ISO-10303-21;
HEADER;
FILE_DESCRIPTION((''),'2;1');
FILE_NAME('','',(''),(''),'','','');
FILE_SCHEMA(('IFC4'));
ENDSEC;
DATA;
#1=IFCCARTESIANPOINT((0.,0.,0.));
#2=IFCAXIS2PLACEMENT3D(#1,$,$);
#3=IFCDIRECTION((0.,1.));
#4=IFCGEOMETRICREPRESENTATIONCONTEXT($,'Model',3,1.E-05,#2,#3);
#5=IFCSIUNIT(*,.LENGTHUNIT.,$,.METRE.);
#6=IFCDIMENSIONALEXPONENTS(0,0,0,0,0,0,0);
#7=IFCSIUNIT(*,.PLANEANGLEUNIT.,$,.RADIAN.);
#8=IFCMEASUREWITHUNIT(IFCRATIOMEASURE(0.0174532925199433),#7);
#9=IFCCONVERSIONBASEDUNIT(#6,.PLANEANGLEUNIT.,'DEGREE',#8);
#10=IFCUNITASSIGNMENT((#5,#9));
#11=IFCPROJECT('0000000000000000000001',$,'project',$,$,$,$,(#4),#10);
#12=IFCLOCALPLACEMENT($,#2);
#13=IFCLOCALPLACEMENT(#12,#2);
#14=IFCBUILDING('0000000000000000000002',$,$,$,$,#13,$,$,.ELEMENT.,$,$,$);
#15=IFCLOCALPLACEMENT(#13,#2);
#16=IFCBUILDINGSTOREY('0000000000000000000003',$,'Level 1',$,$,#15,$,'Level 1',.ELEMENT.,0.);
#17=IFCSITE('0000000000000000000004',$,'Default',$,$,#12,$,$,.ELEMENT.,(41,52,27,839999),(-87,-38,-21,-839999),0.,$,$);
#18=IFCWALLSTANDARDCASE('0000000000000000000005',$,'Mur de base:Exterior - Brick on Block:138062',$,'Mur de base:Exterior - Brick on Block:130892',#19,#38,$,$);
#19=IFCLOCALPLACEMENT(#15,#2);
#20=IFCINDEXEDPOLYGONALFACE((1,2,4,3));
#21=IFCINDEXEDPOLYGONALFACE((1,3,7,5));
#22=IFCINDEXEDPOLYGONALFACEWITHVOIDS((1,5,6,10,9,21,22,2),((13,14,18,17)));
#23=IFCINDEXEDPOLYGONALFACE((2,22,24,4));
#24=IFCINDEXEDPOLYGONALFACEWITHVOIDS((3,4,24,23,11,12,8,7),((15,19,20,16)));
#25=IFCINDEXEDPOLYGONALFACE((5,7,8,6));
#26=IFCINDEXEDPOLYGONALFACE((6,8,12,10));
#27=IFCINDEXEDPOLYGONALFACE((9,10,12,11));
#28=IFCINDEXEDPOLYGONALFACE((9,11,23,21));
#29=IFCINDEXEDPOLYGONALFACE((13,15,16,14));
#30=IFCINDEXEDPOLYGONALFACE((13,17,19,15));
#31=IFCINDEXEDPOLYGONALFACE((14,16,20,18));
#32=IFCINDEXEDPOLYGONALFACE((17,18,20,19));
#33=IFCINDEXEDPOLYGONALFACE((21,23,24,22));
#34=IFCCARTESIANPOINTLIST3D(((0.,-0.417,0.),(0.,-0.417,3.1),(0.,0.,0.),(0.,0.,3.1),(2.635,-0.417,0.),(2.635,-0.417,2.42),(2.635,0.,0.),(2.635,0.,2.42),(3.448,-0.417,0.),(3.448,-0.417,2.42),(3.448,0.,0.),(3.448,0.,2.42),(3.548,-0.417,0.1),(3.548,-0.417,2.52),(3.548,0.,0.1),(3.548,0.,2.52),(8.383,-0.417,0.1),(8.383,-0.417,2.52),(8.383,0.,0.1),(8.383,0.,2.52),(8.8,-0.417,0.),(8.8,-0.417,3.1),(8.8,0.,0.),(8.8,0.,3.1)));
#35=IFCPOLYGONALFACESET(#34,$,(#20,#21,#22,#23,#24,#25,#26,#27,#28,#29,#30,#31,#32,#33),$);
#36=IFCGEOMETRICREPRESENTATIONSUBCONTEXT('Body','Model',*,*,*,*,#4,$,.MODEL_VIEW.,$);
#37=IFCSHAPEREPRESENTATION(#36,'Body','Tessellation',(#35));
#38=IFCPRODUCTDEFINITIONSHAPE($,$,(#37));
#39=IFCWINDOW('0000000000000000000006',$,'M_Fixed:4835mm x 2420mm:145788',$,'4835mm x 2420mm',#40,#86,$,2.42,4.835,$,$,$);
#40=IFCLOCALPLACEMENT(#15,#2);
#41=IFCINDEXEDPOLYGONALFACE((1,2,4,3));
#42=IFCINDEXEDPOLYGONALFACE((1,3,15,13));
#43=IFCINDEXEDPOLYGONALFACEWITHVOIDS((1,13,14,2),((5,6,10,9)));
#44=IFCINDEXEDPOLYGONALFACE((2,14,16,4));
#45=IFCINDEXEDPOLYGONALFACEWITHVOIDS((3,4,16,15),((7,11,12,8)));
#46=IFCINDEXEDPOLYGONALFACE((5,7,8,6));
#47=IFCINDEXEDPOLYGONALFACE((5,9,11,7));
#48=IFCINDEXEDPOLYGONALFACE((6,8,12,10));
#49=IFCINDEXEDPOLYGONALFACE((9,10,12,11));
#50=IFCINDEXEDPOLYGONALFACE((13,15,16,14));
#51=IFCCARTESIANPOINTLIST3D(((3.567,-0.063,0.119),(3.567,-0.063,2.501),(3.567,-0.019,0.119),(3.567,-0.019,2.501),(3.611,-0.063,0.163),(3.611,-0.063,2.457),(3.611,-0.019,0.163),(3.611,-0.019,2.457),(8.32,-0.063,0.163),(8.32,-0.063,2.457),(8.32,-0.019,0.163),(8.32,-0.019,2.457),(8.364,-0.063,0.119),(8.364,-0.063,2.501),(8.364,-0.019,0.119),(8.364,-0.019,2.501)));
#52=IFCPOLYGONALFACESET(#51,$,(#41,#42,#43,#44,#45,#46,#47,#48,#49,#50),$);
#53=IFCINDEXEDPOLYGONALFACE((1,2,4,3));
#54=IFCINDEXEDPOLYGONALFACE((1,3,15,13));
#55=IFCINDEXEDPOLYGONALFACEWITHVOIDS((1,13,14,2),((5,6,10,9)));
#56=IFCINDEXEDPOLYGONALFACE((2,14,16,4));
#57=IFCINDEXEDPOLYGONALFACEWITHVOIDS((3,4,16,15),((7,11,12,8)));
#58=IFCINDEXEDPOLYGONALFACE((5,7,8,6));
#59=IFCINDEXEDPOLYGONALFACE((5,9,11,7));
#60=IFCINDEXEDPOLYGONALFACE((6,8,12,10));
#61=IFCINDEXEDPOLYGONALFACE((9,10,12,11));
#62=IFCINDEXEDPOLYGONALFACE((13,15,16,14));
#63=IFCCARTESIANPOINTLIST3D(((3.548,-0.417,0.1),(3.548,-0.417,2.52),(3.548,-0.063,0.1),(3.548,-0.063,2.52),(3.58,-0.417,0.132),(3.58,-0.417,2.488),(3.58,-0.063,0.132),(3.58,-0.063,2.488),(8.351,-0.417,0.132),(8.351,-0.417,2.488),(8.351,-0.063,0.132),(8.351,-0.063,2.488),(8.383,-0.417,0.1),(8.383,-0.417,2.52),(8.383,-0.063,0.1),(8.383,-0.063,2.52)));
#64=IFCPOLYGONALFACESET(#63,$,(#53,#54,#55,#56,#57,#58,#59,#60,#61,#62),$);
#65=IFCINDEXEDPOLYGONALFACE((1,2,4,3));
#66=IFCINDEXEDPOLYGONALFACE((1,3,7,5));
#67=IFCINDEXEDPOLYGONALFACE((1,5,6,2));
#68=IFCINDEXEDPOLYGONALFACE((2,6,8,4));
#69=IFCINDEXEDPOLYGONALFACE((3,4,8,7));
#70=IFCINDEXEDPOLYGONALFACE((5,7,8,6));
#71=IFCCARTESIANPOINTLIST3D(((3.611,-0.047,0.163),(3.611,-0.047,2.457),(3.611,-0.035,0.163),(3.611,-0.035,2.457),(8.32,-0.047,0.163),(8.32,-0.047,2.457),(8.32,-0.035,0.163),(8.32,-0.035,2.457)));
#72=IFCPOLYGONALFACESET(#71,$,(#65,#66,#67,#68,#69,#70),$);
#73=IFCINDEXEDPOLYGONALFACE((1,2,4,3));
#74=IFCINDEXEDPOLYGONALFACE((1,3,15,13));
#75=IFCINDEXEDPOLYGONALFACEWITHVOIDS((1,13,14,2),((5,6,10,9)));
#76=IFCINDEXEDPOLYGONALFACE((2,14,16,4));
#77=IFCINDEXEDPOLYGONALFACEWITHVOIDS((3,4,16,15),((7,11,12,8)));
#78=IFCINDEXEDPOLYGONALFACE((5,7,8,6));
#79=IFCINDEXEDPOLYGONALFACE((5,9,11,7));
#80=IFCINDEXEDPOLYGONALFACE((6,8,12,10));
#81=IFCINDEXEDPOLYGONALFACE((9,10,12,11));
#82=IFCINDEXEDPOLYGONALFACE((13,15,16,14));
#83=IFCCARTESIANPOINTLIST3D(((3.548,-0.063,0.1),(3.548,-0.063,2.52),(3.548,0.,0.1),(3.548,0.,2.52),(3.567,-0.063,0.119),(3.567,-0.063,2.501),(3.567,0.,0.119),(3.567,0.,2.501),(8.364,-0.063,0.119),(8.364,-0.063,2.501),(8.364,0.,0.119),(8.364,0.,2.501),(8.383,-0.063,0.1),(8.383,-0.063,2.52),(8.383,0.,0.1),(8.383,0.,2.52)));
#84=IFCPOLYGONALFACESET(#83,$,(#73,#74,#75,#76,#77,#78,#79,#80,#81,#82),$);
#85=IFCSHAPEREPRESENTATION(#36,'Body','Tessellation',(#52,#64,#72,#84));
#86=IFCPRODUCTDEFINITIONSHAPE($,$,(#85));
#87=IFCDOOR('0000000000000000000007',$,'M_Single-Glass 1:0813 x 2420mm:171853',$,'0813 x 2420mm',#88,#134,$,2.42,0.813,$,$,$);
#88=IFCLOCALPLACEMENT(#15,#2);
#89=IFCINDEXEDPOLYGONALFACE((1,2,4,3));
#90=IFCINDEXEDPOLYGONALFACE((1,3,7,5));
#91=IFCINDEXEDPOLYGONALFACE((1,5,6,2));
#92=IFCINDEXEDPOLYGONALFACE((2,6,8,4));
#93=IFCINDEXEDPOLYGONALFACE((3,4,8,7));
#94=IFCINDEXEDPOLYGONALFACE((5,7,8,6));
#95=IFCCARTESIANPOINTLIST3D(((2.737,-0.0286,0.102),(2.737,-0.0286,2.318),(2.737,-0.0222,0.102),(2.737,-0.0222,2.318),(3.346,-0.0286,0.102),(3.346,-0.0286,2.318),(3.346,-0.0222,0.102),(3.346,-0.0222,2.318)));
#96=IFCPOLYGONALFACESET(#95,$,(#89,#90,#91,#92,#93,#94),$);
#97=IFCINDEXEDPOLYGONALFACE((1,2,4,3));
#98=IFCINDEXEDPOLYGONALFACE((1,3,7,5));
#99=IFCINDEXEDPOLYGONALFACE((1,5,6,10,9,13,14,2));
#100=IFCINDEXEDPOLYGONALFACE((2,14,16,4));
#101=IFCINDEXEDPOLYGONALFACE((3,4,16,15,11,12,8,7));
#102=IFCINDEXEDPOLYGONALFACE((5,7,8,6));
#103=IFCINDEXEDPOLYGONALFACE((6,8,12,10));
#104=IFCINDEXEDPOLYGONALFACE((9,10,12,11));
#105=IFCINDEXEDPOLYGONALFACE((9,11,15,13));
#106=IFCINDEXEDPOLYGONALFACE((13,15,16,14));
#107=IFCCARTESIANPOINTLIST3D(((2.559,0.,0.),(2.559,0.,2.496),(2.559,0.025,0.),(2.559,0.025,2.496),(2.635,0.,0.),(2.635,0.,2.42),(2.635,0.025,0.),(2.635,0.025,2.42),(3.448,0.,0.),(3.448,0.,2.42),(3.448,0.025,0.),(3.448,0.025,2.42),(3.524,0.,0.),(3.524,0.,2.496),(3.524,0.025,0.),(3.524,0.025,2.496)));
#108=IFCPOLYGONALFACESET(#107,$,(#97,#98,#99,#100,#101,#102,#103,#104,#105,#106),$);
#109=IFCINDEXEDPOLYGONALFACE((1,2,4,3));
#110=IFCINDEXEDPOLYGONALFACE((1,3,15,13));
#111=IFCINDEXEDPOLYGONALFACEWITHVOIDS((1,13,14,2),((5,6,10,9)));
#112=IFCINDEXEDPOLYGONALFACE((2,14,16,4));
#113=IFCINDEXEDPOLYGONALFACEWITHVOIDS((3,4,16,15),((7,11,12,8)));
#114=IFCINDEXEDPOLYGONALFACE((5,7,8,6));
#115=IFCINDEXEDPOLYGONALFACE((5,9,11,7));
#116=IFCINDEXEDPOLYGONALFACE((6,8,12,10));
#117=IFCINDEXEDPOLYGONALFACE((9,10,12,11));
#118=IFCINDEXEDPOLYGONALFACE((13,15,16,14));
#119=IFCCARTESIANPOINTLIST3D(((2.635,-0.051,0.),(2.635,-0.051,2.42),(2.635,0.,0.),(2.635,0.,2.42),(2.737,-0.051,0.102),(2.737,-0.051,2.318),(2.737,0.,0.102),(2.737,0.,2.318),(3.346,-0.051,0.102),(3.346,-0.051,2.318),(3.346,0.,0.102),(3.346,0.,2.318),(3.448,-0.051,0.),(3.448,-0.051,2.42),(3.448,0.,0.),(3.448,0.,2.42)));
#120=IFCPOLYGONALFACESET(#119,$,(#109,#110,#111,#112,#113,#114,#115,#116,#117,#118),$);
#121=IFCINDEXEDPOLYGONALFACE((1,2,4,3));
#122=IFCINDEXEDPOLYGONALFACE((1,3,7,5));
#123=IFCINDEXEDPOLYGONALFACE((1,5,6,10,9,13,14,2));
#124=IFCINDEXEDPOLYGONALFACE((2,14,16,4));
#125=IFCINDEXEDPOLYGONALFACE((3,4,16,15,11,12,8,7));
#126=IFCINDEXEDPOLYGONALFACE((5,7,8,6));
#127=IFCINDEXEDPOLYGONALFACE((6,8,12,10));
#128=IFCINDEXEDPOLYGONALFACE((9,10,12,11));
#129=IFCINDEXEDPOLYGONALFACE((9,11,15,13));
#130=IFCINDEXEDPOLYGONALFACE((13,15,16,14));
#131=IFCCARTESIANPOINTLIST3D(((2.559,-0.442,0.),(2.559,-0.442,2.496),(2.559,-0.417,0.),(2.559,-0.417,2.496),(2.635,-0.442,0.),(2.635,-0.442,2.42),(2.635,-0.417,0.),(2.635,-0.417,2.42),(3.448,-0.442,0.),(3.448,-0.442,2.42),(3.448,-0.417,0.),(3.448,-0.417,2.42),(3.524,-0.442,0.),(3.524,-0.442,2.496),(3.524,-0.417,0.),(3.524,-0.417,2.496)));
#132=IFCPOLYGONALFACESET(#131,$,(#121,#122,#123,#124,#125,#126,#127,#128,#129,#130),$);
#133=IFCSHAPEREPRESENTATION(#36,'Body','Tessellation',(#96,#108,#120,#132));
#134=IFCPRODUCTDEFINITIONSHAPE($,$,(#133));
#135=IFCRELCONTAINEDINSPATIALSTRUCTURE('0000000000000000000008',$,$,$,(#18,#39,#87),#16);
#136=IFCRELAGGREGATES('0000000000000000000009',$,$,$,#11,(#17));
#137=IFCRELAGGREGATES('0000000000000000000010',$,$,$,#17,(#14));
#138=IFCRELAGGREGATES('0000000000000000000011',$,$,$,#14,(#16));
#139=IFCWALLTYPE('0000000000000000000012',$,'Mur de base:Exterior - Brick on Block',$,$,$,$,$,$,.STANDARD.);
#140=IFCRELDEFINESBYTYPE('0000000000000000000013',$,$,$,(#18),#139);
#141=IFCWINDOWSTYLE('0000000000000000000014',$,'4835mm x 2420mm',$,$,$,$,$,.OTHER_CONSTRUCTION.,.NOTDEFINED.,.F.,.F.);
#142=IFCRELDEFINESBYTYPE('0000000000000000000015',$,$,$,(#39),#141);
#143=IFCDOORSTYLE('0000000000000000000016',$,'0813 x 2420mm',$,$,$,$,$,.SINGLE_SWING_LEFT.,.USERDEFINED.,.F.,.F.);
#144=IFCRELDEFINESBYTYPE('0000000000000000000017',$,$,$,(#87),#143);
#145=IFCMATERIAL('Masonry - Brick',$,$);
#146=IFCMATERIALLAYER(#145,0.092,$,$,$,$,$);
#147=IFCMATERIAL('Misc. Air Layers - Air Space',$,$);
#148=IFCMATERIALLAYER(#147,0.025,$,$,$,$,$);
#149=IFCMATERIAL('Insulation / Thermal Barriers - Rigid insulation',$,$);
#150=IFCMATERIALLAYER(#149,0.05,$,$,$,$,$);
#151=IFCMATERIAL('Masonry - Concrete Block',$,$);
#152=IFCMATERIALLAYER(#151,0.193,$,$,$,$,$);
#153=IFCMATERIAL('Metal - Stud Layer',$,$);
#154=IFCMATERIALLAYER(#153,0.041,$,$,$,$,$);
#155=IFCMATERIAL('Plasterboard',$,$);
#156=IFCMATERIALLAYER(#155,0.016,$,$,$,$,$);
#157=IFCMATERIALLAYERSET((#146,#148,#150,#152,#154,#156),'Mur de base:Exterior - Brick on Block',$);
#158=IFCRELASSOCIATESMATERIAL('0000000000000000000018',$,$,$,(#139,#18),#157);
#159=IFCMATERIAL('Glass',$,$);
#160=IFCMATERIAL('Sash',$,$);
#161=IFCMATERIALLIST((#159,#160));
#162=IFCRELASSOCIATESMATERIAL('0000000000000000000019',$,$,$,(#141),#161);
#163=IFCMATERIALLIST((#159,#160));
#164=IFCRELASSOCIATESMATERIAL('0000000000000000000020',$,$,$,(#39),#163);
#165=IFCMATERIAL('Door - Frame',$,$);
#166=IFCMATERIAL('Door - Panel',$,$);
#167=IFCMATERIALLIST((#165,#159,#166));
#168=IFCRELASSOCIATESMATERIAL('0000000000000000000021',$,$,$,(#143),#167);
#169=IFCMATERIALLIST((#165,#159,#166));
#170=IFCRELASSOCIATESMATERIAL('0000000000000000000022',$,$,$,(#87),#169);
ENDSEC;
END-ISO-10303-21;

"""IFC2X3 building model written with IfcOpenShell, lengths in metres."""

from ifc_helpers import new_model, entity, si_unit, converted_unit, direction, frame, frame_2d, origin, origin_2d_with_axis, place, context, subcontext, project, spatial, polyline, rectangle, outline, extrude, source, transform, mapped, material, material_list, layer, layer_set, layer_usage, type_object, type_shapes, element, fill, save


model = new_model("IFC2X3")

# Units and contexts
model_context = context("Model", 3, precision=1e-05, world=origin(), true_north=direction((0.0, 1.0)))
body_context = subcontext(model_context, "Body", "Model", "MODEL_VIEW")
ifc_project = project(units=[si_unit("LENGTHUNIT", "METRE"), converted_unit("PLANEANGLEUNIT", "DEGREE", entity("IfcRatioMeasure", 0.0174532925199433), si_unit("PLANEANGLEUNIT", "RADIAN"), dimensions=[0, 0, 0, 0, 0, 0, 0])], contexts=[model_context])

# Site, building, storey
site_placement = place(None, origin())
site = spatial("IfcSite", under=ifc_project, at=site_placement, Name="Default", CompositionType="ELEMENT", RefLatitude=(41, 52, 27, 839999), RefLongitude=(-87, -38, -21, -839999), RefElevation=0.0)
building_placement = place(site_placement, origin())
building = spatial("IfcBuilding", under=site, at=building_placement, CompositionType="ELEMENT")
storey_placement = place(building_placement, origin())
storey = spatial("IfcBuildingStorey", under=building, at=storey_placement, Name="Level 1", LongName="Level 1", CompositionType="ELEMENT", Elevation=0.0)

# Wall, openings, window, door
ifc_material_1 = material(Name="Masonry - Brick")
ifc_layer_1 = layer(ifc_material_1, 0.092)
ifc_material_2 = material(Name="Misc. Air Layers - Air Space")
ifc_layer_2 = layer(ifc_material_2, 0.025)
ifc_material_3 = material(Name="Insulation / Thermal Barriers - Rigid insulation")
ifc_layer_3 = layer(ifc_material_3, 0.05)
ifc_material_4 = material(Name="Masonry - Concrete Block")
ifc_layer_4 = layer(ifc_material_4, 0.193)
ifc_material_5 = material(Name="Metal - Stud Layer")
ifc_layer_5 = layer(ifc_material_5, 0.041)
ifc_material_6 = material(Name="Plasterboard")
ifc_layer_6 = layer(ifc_material_6, 0.016)
ifc_layer_set_1 = layer_set([ifc_layer_1, ifc_layer_2, ifc_layer_3, ifc_layer_4, ifc_layer_5, ifc_layer_6], Name="Mur de base:Exterior - Brick on Block")
ifc_layer_usage_1 = layer_usage(ifc_layer_set_1, "AXIS2", "NEGATIVE", 0.2085)
wall_type_1 = type_object("IfcWallType", Name="Mur de base:Exterior - Brick on Block", PredefinedType="STANDARD", material=ifc_layer_set_1)
wall_1_placement = place(storey_placement, frame((0.0, -0.2085, 0.0)))
wall_1 = element("IfcWallStandardCase", 1, at=wall_1_placement, inside=storey, type_object=wall_type_1, material=ifc_layer_usage_1, Name="Mur de base:Exterior - Brick on Block:138062", ObjectType="Mur de base:Exterior - Brick on Block:130892", context=body_context, shape_type="SweptSolid", body=[
    extrude(rectangle(XDim=8.8, YDim=0.417, at=frame_2d((4.4, 0.0), x_axis=(-1.0, 0.0))), origin(), (0.0, 0.0, 1.0), 3.1),
])
opening_1_placement = place(wall_1_placement, frame((2.635, -0.2085, 0.0)))
opening_1 = element("IfcOpeningElement", 2, at=opening_1_placement, cuts=wall_1, ObjectType="Opening", context=body_context, shape_type="SweptSolid", body=[
    extrude(rectangle(XDim=0.813, YDim=2.42, at=frame_2d((1.21, 0.4065), x_axis=(0.0, -1.0))), frame((0.0, 0.0, 0.0), z_axis=(0.0, 1.0, 0.0), x_axis=(0.0, 0.0, 1.0)), (0.0, 0.0, 1.0), 0.417),
])
opening_2_placement = place(wall_1_placement, frame((3.548, -0.2085, 0.1)))
opening_2 = element("IfcOpeningElement", 3, at=opening_2_placement, cuts=wall_1, ObjectType="Opening", context=body_context, shape_type="SweptSolid", body=[
    extrude(rectangle(XDim=2.42, YDim=4.835, at=frame_2d((1.21, 2.4175), x_axis=(1.0, 0.0))), frame((0.0, 0.0, 0.0), z_axis=(0.0, 1.0, 0.0), x_axis=(0.0, 0.0, 1.0)), (0.0, 0.0, 1.0), 0.417),
])
ifc_material_7 = material(Name="Glass")
ifc_material_8 = material(Name="Sash")
ifc_material_list_1 = material_list([ifc_material_7, ifc_material_8])
ifc_material_list_2 = material_list([ifc_material_7, ifc_material_8])
window_style_1 = type_object("IfcWindowStyle", Name="4835mm x 2420mm", ConstructionType="OTHER_CONSTRUCTION", OperationType="NOTDEFINED", ParameterTakesPrecedence=False, Sizeable=False, material=ifc_material_list_2)
shared_shape_1 = source(origin(), body_context, "Body", "SweptSolid", [
    extrude(outline(polyline([(-2.3985, -1.191), (2.3985, -1.191), (2.3985, 1.191), (-2.3985, 1.191), (-2.3985, -1.191)]), holes=[polyline([(-2.3545, -1.147), (-2.3545, 1.147), (2.3545, 1.147), (2.3545, -1.147), (-2.3545, -1.147)])]), frame((2.4175, 0.354, 1.21), z_axis=(0.0, 1.0, 0.0), x_axis=(1.0, 0.0, 0.0)), (0.0, 0.0, 1.0), 0.044),
    extrude(outline(polyline([(-2.4175, -1.21), (2.4175, -1.21), (2.4175, 1.21), (-2.4175, 1.21), (-2.4175, -1.21)]), holes=[polyline([(-2.3855, -1.178), (-2.3855, 1.178), (2.3855, 1.178), (2.3855, -1.178), (-2.3855, -1.178)])]), frame((2.4175, 0.0, 1.21), z_axis=(0.0, 1.0, 0.0), x_axis=(1.0, 0.0, 0.0)), (0.0, 0.0, 1.0), 0.354),
    extrude(rectangle(XDim=0.012, YDim=4.709, at=origin_2d_with_axis()), frame((2.4175, 0.376, 0.063), z_axis=(0.0, 0.0, 1.0), x_axis=(0.0, -1.0, 0.0)), (0.0, 0.0, 1.0), 2.294),
    extrude(outline(polyline([(-2.4175, -1.21), (2.4175, -1.21), (2.4175, 1.21), (-2.4175, 1.21), (-2.4175, -1.21)]), holes=[polyline([(-2.3985, -1.191), (-2.3985, 1.191), (2.3985, 1.191), (2.3985, -1.191), (-2.3985, -1.191)])]), frame((2.4175, 0.354, 1.21), z_axis=(0.0, 1.0, 0.0), x_axis=(1.0, 0.0, 0.0)), (0.0, 0.0, 1.0), 0.063),
])
type_shapes(window_style_1, [shared_shape_1])
window_1_placement = place(opening_2_placement, origin())
window_1 = element("IfcWindow", 4, at=window_1_placement, inside=storey, type_object=window_style_1, material=ifc_material_list_1, Name="M_Fixed:4835mm x 2420mm:145788", ObjectType="4835mm x 2420mm", OverallHeight=2.42, OverallWidth=4.835, context=body_context, shape_type="MappedRepresentation", body=[
    mapped(shared_shape_1, transform((0.0, 0.0, 0.0), scale=1.0)),
])
fill(opening_2, window_1)
ifc_material_9 = material(Name="Door - Frame")
ifc_material_10 = material(Name="Door - Panel")
ifc_material_list_3 = material_list([ifc_material_9, ifc_material_7, ifc_material_10])
ifc_material_list_4 = material_list([ifc_material_9, ifc_material_7, ifc_material_10])
door_style_1 = type_object("IfcDoorStyle", Name="0813 x 2420mm", ConstructionType="USERDEFINED", OperationType="SINGLE_SWING_LEFT", ParameterTakesPrecedence=False, Sizeable=False, material=ifc_material_list_4)
shared_shape_2 = source(origin(), body_context, "Body", "SweptSolid", [
    extrude(rectangle(XDim=0.609, YDim=0.0064, at=frame_2d((0.0, 0.0), x_axis=(1.0, 0.0))), frame((0.4065, 0.3916, 0.102)), (0.0, 0.0, 1.0), 2.216),
    extrude(outline(polyline([(-0.4065, -1.191), (-0.4065, 1.229), (-0.4825, 1.229), (-0.4825, -1.267), (0.4825, -1.267), (0.4825, 1.229), (0.4065, 1.229), (0.4065, -1.191), (-0.4065, -1.191)])), frame((0.4065, 0.442, 1.229), z_axis=(0.0, 1.0, 0.0), x_axis=(1.0, 0.0, 0.0)), (0.0, 0.0, -1.0), 0.025),
    extrude(outline(polyline([(-1.21, -0.4065), (1.21, -0.4065), (1.21, 0.4065), (-1.21, 0.4065), (-1.21, -0.4065)]), holes=[polyline([(-1.108, 0.3045), (1.108, 0.3045), (1.108, -0.3045), (-1.108, -0.3045), (-1.108, 0.3045)])]), frame((0.4065, 0.417, 1.21), z_axis=(0.0, -1.0, 0.0), x_axis=(0.0, 0.0, -1.0)), (0.0, 0.0, 1.0), 0.051),
    extrude(outline(polyline([(-0.4065, -1.191), (-0.4065, 1.229), (-0.4825, 1.229), (-0.4825, -1.267), (0.4825, -1.267), (0.4825, 1.229), (0.4065, 1.229), (0.4065, -1.191), (-0.4065, -1.191)])), frame((0.4065, 0.0, 1.229), z_axis=(0.0, 1.0, 0.0), x_axis=(1.0, 0.0, 0.0)), (0.0, 0.0, -1.0), 0.025),
])
type_shapes(door_style_1, [shared_shape_2])
door_1_placement = place(opening_1_placement, origin())
door_1 = element("IfcDoor", 5, at=door_1_placement, inside=storey, type_object=door_style_1, material=ifc_material_list_3, Name="M_Single-Glass 1:0813 x 2420mm:171853", ObjectType="0813 x 2420mm", OverallHeight=2.42, OverallWidth=0.813, context=body_context, shape_type="MappedRepresentation", body=[
    mapped(shared_shape_2, transform((0.0, 0.0, 0.0), scale=1.0)),
])
fill(opening_1, door_1)

save(model, "model.ifc")
